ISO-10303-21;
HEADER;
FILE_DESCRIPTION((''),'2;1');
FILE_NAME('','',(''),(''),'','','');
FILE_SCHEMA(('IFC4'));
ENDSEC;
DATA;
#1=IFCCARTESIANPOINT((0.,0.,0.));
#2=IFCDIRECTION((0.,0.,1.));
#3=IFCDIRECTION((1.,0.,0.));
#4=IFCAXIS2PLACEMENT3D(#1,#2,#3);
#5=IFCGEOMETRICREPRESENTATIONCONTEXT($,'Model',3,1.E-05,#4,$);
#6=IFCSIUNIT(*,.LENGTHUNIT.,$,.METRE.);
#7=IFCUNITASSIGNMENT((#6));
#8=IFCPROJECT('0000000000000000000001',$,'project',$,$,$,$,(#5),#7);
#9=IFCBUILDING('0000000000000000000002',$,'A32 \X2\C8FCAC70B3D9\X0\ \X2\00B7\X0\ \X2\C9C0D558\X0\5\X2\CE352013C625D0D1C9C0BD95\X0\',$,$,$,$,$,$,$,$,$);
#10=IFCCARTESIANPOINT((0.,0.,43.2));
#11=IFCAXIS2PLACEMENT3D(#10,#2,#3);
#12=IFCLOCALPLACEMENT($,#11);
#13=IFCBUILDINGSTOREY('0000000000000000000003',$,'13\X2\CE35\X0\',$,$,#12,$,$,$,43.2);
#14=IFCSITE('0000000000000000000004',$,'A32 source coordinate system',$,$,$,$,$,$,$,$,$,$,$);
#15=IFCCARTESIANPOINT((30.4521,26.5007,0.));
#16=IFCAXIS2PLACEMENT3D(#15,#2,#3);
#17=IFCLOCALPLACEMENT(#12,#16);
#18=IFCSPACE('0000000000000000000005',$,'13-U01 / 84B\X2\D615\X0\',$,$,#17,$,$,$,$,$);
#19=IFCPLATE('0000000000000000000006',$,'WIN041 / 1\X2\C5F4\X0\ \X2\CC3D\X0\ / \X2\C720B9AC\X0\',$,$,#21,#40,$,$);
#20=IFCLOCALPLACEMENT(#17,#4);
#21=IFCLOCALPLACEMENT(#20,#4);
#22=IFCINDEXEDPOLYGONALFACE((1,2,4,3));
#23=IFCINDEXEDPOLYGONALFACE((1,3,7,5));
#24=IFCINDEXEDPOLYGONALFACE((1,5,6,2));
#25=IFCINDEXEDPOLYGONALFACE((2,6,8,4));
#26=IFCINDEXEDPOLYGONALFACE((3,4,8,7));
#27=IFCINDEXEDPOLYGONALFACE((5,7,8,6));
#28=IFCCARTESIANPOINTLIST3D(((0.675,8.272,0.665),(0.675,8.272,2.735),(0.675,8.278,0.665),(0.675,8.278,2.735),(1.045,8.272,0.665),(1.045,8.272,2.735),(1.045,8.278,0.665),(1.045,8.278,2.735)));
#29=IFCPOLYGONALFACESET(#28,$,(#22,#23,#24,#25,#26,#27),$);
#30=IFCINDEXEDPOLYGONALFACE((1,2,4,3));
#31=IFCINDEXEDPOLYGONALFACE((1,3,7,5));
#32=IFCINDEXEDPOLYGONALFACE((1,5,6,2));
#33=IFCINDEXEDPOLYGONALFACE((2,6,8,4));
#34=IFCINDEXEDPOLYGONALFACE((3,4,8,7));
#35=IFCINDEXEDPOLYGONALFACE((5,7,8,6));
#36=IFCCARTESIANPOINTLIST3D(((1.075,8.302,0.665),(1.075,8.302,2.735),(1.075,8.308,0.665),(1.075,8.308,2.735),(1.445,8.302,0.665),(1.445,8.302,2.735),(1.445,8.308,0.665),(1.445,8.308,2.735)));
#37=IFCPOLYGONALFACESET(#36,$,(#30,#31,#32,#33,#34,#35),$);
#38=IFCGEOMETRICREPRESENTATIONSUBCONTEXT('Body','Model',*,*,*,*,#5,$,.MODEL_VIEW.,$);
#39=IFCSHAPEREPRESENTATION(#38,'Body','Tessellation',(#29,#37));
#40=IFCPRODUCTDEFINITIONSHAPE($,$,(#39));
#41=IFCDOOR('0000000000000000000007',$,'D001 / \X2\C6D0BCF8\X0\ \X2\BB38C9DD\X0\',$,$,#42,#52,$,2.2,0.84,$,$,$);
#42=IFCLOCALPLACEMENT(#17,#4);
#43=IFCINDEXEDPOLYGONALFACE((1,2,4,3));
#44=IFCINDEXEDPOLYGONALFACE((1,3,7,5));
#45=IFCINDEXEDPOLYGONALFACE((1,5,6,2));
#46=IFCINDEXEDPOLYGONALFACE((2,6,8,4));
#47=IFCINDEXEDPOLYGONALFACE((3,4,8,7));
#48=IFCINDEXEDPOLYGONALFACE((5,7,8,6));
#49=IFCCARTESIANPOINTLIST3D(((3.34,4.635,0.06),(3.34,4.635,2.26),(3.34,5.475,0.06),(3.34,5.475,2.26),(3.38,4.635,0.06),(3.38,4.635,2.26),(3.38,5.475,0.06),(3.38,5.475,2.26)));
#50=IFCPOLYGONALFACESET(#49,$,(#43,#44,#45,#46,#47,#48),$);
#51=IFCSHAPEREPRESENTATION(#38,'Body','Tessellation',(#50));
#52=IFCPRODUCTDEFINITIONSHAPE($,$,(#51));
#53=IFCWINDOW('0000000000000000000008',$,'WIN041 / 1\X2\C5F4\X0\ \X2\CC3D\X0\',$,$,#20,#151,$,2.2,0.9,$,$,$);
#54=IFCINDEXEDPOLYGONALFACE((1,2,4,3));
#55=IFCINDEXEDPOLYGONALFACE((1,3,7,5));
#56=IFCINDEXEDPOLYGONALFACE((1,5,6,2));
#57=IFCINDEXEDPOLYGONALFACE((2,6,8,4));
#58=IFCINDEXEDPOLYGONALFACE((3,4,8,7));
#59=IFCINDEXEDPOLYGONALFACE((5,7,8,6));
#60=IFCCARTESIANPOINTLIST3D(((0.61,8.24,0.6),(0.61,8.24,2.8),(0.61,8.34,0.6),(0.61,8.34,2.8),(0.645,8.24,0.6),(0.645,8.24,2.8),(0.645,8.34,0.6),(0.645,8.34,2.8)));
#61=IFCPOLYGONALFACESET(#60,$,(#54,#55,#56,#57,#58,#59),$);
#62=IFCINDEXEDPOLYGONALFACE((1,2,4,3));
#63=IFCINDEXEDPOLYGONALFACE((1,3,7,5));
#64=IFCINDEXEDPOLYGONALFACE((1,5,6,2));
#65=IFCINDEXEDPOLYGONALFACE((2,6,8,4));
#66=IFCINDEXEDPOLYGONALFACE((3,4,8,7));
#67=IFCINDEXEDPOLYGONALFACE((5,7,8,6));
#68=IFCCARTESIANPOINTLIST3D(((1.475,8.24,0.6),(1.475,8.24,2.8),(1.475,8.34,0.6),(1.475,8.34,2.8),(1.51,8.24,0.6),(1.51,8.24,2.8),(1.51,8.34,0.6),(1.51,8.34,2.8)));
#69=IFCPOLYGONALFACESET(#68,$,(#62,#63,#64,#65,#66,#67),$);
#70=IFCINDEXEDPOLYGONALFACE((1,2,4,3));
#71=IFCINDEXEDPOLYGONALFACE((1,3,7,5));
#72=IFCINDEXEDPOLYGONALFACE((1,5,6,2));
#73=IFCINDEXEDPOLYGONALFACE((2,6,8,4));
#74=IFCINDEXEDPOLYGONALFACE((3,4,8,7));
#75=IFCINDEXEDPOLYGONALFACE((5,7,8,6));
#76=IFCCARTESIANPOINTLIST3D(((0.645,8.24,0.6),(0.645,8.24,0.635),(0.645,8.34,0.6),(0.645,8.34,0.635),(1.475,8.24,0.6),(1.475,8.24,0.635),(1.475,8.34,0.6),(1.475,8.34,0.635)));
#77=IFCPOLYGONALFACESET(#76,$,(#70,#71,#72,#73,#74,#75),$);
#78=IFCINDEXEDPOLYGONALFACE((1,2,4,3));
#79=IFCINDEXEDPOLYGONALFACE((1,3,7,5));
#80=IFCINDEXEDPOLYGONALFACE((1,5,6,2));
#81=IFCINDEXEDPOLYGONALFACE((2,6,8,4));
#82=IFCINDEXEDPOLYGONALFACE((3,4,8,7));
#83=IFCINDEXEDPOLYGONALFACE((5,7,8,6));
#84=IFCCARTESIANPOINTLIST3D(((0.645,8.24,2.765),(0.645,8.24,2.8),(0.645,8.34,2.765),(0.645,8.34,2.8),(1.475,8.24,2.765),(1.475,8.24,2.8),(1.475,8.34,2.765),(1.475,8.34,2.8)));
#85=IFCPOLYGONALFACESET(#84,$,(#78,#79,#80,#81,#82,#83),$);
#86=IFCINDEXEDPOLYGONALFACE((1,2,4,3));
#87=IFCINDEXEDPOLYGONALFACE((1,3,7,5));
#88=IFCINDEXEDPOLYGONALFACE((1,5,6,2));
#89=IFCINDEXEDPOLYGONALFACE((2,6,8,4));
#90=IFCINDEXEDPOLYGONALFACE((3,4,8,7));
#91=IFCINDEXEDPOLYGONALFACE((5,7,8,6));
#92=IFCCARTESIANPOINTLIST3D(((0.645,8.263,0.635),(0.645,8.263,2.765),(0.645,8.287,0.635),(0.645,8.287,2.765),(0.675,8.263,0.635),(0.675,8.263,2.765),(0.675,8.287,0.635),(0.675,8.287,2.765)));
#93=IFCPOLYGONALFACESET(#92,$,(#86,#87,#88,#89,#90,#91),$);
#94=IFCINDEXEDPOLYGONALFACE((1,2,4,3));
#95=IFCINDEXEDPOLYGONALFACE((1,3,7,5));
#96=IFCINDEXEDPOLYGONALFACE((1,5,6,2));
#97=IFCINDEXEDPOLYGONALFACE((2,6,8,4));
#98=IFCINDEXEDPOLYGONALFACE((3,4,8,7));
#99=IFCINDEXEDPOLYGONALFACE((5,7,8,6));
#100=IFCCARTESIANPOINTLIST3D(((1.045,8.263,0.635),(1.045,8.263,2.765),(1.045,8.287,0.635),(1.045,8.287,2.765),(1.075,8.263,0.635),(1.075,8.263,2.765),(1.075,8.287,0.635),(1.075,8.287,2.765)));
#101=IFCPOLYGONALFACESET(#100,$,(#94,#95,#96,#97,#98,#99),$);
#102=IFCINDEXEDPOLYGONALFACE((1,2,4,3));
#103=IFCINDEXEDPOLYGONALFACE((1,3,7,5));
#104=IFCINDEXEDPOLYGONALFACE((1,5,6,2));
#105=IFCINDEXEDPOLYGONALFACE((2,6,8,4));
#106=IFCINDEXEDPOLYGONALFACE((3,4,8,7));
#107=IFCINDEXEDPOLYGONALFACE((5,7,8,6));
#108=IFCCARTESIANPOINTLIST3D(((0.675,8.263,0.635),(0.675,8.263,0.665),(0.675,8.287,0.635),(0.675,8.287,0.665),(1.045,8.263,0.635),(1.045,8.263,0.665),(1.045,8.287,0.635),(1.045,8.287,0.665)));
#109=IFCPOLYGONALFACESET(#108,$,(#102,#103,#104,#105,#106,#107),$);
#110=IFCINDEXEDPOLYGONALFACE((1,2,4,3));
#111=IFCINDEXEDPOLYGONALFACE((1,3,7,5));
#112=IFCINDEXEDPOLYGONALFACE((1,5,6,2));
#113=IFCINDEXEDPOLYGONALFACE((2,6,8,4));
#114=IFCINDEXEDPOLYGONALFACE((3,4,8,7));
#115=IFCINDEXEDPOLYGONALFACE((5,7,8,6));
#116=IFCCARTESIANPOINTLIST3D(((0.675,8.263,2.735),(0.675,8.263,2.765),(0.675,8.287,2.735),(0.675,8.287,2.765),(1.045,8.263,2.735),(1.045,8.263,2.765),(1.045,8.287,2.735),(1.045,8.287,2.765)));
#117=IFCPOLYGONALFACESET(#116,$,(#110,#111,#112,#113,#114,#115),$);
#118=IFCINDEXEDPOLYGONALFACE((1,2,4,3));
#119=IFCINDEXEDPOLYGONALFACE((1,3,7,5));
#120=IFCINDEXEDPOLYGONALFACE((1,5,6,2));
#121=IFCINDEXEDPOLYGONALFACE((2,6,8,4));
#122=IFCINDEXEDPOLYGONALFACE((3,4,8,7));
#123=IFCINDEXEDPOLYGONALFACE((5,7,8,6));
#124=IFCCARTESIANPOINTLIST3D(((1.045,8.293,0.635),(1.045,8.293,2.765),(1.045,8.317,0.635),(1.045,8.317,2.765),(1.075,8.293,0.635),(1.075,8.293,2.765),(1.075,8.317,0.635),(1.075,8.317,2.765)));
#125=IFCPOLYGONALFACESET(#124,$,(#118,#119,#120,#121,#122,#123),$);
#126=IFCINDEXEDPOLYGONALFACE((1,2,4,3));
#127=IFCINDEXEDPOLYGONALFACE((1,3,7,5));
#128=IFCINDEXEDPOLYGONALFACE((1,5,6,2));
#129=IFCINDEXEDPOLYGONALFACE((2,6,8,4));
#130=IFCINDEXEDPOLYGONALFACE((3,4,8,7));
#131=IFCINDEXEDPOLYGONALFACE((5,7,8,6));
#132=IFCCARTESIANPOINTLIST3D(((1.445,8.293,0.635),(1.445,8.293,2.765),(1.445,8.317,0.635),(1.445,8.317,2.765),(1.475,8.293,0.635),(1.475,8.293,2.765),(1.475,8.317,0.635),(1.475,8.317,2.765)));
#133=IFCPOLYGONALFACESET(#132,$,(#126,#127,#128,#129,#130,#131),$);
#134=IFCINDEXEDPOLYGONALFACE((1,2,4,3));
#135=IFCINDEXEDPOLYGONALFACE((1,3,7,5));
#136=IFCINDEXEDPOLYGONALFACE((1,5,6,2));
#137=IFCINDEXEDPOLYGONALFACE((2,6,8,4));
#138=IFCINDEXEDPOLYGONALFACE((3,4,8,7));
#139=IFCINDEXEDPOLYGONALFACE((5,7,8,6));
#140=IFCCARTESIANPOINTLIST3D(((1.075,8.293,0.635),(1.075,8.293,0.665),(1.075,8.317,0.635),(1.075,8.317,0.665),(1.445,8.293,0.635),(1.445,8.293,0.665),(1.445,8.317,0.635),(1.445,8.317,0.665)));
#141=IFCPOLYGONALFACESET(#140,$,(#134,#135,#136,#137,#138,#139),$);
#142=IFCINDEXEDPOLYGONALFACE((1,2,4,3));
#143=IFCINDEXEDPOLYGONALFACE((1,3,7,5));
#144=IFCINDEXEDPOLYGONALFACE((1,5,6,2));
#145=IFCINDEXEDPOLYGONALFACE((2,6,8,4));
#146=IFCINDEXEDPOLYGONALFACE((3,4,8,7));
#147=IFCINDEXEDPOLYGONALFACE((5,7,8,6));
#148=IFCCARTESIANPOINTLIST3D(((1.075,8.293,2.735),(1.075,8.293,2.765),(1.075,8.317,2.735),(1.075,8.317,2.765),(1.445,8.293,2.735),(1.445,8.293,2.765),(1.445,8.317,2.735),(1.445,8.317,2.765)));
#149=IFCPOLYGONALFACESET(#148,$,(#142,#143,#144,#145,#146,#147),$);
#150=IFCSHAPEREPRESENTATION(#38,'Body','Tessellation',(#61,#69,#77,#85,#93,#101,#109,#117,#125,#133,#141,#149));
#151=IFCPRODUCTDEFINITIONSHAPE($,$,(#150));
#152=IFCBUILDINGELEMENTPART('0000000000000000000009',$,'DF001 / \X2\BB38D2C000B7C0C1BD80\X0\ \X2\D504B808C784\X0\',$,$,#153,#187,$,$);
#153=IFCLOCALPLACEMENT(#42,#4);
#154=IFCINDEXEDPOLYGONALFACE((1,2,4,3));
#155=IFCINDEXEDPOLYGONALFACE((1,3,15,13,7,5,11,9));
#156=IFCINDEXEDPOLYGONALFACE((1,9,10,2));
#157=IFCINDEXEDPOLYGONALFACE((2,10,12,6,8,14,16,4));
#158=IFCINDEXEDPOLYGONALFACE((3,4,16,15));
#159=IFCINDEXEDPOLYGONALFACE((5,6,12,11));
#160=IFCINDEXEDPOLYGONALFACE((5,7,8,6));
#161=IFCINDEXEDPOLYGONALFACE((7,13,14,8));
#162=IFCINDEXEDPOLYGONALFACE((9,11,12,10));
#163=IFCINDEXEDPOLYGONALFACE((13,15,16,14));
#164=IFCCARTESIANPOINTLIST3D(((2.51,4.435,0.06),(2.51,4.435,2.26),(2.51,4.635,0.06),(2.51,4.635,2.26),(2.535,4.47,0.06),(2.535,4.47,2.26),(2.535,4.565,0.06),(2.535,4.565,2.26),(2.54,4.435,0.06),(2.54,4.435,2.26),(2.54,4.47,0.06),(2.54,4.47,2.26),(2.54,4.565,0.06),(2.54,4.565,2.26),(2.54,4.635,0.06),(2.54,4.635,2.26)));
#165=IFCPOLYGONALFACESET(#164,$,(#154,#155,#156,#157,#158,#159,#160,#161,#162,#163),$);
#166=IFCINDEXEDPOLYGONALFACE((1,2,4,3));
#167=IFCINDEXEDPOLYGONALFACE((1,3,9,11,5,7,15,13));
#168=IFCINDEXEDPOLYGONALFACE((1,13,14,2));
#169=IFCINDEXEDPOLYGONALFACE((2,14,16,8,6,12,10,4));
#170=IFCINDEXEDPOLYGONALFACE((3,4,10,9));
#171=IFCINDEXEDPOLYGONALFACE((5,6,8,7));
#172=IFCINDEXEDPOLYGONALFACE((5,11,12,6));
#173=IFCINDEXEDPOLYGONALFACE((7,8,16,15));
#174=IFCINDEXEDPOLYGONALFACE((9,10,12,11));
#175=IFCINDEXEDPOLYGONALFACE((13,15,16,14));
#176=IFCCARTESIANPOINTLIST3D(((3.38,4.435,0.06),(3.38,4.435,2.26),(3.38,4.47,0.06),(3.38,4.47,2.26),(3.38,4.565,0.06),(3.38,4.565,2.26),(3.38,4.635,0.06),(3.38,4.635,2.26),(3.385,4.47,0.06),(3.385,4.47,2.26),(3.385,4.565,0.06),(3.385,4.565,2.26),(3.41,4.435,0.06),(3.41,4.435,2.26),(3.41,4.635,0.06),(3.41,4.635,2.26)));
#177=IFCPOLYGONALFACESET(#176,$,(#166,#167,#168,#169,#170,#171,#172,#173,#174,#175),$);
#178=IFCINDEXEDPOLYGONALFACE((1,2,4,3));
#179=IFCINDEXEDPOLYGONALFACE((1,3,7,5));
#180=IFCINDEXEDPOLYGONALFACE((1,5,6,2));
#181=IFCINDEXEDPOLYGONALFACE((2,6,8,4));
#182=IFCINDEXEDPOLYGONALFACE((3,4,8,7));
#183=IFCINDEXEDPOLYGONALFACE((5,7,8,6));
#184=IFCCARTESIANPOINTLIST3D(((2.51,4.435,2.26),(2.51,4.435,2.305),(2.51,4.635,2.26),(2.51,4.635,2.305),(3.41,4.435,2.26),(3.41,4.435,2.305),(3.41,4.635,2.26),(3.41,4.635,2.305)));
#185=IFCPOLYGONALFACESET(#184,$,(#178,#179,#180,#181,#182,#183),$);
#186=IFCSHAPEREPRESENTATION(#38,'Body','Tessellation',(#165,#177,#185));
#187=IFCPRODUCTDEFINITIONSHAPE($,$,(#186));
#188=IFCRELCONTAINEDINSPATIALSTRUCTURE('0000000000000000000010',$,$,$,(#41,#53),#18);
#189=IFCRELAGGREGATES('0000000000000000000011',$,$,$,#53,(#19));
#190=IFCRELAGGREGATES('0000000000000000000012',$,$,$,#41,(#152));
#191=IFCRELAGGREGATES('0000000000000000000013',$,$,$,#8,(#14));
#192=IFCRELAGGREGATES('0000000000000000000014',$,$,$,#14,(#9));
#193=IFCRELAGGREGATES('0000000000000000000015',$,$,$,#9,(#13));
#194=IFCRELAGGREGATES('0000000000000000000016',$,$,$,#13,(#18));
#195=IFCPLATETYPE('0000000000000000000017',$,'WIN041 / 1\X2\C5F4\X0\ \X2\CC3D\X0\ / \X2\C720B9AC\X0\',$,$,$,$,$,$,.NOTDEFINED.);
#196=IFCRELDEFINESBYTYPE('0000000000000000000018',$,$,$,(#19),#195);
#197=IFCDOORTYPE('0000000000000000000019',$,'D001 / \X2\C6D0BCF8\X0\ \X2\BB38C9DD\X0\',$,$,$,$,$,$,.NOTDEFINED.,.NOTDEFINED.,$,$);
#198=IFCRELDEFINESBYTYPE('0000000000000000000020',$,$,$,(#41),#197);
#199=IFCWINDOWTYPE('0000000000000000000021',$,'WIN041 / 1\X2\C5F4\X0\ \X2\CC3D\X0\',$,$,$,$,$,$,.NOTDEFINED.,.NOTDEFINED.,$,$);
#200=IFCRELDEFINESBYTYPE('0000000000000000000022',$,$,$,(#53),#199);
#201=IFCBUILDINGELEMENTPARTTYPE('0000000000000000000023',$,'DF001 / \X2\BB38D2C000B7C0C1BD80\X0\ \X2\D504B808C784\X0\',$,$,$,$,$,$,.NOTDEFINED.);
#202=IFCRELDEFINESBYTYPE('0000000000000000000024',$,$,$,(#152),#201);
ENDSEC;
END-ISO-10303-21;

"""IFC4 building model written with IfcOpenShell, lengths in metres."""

from ifc_helpers import new_model, si_unit, frame, origin, origin_with_axes, place, context, subcontext, project, spatial, polyline, outline, extrude, source, transform, mapped, type_object, type_shapes, element, aggregate, save


model = new_model("IFC4")

# Units and contexts
model_context = context("Model", 3, precision=1e-05, world=origin_with_axes())
body_context = subcontext(model_context, "Body", "Model", "MODEL_VIEW")
ifc_project = project(units=[si_unit("LENGTHUNIT", "METRE")], contexts=[model_context])

# Plate
storey_placement = place(None, frame((0.0, 0.0, 43.2), z_axis=(0.0, 0.0, 1.0), x_axis=(1.0, 0.0, 0.0)))
space_placement = place(storey_placement, frame((30.4521, 26.5007, 0.0), z_axis=(0.0, 0.0, 1.0), x_axis=(1.0, 0.0, 0.0)))
plate_type_1 = type_object("IfcPlateType", Name="WIN041 / 1열 창 / 유리", PredefinedType="NOTDEFINED")
shared_shape_1 = source(origin(), body_context, "Body", "SweptSolid", [
    extrude(outline(polyline([(0.675, 8.272), (0.675, 8.278), (1.045, 8.278), (1.045, 8.272), (0.675, 8.272)])), frame((0.0, 0.0, 0.665)), (0.0, 0.0, 1.0), 2.07),
    extrude(outline(polyline([(1.075, 8.302), (1.075, 8.308), (1.445, 8.308), (1.445, 8.302), (1.075, 8.302)])), frame((0.0, 0.0, 0.665)), (0.0, 0.0, 1.0), 2.07),
])
type_shapes(plate_type_1, [shared_shape_1])
window_1_placement = place(space_placement, origin_with_axes())
plate_1_placement = place(window_1_placement, origin_with_axes())
plate_1 = element("IfcPlate", 1, at=plate_1_placement, type_object=plate_type_1, Name="WIN041 / 1열 창 / 유리", context=body_context, shape_type="MappedRepresentation", body=[
    mapped(shared_shape_1, transform((0.0, 0.0, 0.0), scale=1.0)),
])

# Site, building, storey, space
site = spatial("IfcSite", under=ifc_project, Name="A32 source coordinate system")
building = spatial("IfcBuilding", under=site, Name="A32 주거동 · 지하5층–옥탑지붕")
storey = spatial("IfcBuildingStorey", under=building, at=storey_placement, Name="13층", Elevation=43.2)
space = spatial("IfcSpace", under=storey, at=space_placement, Name="13-U01 / 84B형")

# Door
door_type_1 = type_object("IfcDoorType", Name="D001 / 원본 문짝", OperationType="NOTDEFINED", PredefinedType="NOTDEFINED")
shared_shape_2 = source(origin(), body_context, "Body", "SweptSolid", [
    extrude(outline(polyline([(3.34, 5.475), (3.38, 5.475), (3.38, 4.635), (3.34, 4.635), (3.34, 5.475)])), frame((0.0, 0.0, 0.06)), (0.0, 0.0, 1.0), 2.2),
])
type_shapes(door_type_1, [shared_shape_2])
door_1_placement = place(space_placement, origin_with_axes())
door_1 = element("IfcDoor", 2, at=door_1_placement, inside=space, type_object=door_type_1, Name="D001 / 원본 문짝", OverallHeight=2.2, OverallWidth=0.84, context=body_context, shape_type="MappedRepresentation", body=[
    mapped(shared_shape_2, transform((0.0, 0.0, 0.0), scale=1.0)),
])

# Window
window_type_1 = type_object("IfcWindowType", Name="WIN041 / 1열 창", PartitioningType="NOTDEFINED", PredefinedType="NOTDEFINED")
shared_shape_3 = source(origin(), body_context, "Body", "SweptSolid", [
    extrude(outline(polyline([(0.61, 8.24), (0.61, 8.34), (0.645, 8.34), (0.645, 8.24), (0.61, 8.24)])), frame((0.0, 0.0, 0.6)), (0.0, 0.0, 1.0), 2.2),
    extrude(outline(polyline([(1.475, 8.24), (1.475, 8.34), (1.51, 8.34), (1.51, 8.24), (1.475, 8.24)])), frame((0.0, 0.0, 0.6)), (0.0, 0.0, 1.0), 2.2),
    extrude(outline(polyline([(0.645, 8.24), (0.645, 8.34), (1.475, 8.34), (1.475, 8.24), (0.645, 8.24)])), frame((0.0, 0.0, 0.6)), (0.0, 0.0, 1.0), 0.035),
    extrude(outline(polyline([(0.645, 8.24), (0.645, 8.34), (1.475, 8.34), (1.475, 8.24), (0.645, 8.24)])), frame((0.0, 0.0, 2.765)), (0.0, 0.0, 1.0), 0.035),
    extrude(outline(polyline([(0.645, 8.263), (0.645, 8.287), (0.675, 8.287), (0.675, 8.263), (0.645, 8.263)])), frame((0.0, 0.0, 0.635)), (0.0, 0.0, 1.0), 2.13),
    extrude(outline(polyline([(1.045, 8.263), (1.045, 8.287), (1.075, 8.287), (1.075, 8.263), (1.045, 8.263)])), frame((0.0, 0.0, 0.635)), (0.0, 0.0, 1.0), 2.13),
    extrude(outline(polyline([(0.675, 8.263), (0.675, 8.287), (1.045, 8.287), (1.045, 8.263), (0.675, 8.263)])), frame((0.0, 0.0, 0.635)), (0.0, 0.0, 1.0), 0.03),
    extrude(outline(polyline([(0.675, 8.263), (0.675, 8.287), (1.045, 8.287), (1.045, 8.263), (0.675, 8.263)])), frame((0.0, 0.0, 2.735)), (0.0, 0.0, 1.0), 0.03),
    extrude(outline(polyline([(1.045, 8.293), (1.045, 8.317), (1.075, 8.317), (1.075, 8.293), (1.045, 8.293)])), frame((0.0, 0.0, 0.635)), (0.0, 0.0, 1.0), 2.13),
    extrude(outline(polyline([(1.445, 8.293), (1.445, 8.317), (1.475, 8.317), (1.475, 8.293), (1.445, 8.293)])), frame((0.0, 0.0, 0.635)), (0.0, 0.0, 1.0), 2.13),
    extrude(outline(polyline([(1.075, 8.293), (1.075, 8.317), (1.445, 8.317), (1.445, 8.293), (1.075, 8.293)])), frame((0.0, 0.0, 0.635)), (0.0, 0.0, 1.0), 0.03),
    extrude(outline(polyline([(1.075, 8.293), (1.075, 8.317), (1.445, 8.317), (1.445, 8.293), (1.075, 8.293)])), frame((0.0, 0.0, 2.735)), (0.0, 0.0, 1.0), 0.03),
])
type_shapes(window_type_1, [shared_shape_3])
window_1 = element("IfcWindow", 3, at=window_1_placement, inside=space, type_object=window_type_1, Name="WIN041 / 1열 창", OverallHeight=2.2, OverallWidth=0.9, context=body_context, shape_type="MappedRepresentation", body=[
    mapped(shared_shape_3, transform((0.0, 0.0, 0.0), scale=1.0)),
])
aggregate(window_1, [plate_1])

# Building element part
building_element_part_type_1 = type_object("IfcBuildingElementPartType", Name="DF001 / 문틀·상부 프레임", PredefinedType="NOTDEFINED")
shared_shape_4 = source(origin(), body_context, "Body", "SweptSolid", [
    extrude(outline(polyline([(2.54, 4.635), (2.54, 4.565), (2.535, 4.565), (2.535, 4.47), (2.54, 4.47), (2.54, 4.435), (2.51, 4.435), (2.51, 4.635), (2.54, 4.635)])), frame((0.0, 0.0, 0.06)), (0.0, 0.0, 1.0), 2.2),
    extrude(outline(polyline([(3.41, 4.435), (3.38, 4.435), (3.38, 4.47), (3.385, 4.47), (3.385, 4.565), (3.38, 4.565), (3.38, 4.635), (3.41, 4.635), (3.41, 4.435)])), frame((0.0, 0.0, 0.06)), (0.0, 0.0, 1.0), 2.2),
    extrude(outline(polyline([(2.51, 4.435), (2.51, 4.635), (3.41, 4.635), (3.41, 4.435), (2.51, 4.435)])), frame((0.0, 0.0, 2.26)), (0.0, 0.0, 1.0), 0.045),
])
type_shapes(building_element_part_type_1, [shared_shape_4])
building_element_part_1_placement = place(door_1_placement, origin_with_axes())
building_element_part_1 = element("IfcBuildingElementPart", 4, at=building_element_part_1_placement, type_object=building_element_part_type_1, Name="DF001 / 문틀·상부 프레임", context=body_context, shape_type="MappedRepresentation", body=[
    mapped(shared_shape_4, transform((0.0, 0.0, 0.0), scale=1.0)),
])
aggregate(door_1, [building_element_part_1])

save(model, "model.ifc")
